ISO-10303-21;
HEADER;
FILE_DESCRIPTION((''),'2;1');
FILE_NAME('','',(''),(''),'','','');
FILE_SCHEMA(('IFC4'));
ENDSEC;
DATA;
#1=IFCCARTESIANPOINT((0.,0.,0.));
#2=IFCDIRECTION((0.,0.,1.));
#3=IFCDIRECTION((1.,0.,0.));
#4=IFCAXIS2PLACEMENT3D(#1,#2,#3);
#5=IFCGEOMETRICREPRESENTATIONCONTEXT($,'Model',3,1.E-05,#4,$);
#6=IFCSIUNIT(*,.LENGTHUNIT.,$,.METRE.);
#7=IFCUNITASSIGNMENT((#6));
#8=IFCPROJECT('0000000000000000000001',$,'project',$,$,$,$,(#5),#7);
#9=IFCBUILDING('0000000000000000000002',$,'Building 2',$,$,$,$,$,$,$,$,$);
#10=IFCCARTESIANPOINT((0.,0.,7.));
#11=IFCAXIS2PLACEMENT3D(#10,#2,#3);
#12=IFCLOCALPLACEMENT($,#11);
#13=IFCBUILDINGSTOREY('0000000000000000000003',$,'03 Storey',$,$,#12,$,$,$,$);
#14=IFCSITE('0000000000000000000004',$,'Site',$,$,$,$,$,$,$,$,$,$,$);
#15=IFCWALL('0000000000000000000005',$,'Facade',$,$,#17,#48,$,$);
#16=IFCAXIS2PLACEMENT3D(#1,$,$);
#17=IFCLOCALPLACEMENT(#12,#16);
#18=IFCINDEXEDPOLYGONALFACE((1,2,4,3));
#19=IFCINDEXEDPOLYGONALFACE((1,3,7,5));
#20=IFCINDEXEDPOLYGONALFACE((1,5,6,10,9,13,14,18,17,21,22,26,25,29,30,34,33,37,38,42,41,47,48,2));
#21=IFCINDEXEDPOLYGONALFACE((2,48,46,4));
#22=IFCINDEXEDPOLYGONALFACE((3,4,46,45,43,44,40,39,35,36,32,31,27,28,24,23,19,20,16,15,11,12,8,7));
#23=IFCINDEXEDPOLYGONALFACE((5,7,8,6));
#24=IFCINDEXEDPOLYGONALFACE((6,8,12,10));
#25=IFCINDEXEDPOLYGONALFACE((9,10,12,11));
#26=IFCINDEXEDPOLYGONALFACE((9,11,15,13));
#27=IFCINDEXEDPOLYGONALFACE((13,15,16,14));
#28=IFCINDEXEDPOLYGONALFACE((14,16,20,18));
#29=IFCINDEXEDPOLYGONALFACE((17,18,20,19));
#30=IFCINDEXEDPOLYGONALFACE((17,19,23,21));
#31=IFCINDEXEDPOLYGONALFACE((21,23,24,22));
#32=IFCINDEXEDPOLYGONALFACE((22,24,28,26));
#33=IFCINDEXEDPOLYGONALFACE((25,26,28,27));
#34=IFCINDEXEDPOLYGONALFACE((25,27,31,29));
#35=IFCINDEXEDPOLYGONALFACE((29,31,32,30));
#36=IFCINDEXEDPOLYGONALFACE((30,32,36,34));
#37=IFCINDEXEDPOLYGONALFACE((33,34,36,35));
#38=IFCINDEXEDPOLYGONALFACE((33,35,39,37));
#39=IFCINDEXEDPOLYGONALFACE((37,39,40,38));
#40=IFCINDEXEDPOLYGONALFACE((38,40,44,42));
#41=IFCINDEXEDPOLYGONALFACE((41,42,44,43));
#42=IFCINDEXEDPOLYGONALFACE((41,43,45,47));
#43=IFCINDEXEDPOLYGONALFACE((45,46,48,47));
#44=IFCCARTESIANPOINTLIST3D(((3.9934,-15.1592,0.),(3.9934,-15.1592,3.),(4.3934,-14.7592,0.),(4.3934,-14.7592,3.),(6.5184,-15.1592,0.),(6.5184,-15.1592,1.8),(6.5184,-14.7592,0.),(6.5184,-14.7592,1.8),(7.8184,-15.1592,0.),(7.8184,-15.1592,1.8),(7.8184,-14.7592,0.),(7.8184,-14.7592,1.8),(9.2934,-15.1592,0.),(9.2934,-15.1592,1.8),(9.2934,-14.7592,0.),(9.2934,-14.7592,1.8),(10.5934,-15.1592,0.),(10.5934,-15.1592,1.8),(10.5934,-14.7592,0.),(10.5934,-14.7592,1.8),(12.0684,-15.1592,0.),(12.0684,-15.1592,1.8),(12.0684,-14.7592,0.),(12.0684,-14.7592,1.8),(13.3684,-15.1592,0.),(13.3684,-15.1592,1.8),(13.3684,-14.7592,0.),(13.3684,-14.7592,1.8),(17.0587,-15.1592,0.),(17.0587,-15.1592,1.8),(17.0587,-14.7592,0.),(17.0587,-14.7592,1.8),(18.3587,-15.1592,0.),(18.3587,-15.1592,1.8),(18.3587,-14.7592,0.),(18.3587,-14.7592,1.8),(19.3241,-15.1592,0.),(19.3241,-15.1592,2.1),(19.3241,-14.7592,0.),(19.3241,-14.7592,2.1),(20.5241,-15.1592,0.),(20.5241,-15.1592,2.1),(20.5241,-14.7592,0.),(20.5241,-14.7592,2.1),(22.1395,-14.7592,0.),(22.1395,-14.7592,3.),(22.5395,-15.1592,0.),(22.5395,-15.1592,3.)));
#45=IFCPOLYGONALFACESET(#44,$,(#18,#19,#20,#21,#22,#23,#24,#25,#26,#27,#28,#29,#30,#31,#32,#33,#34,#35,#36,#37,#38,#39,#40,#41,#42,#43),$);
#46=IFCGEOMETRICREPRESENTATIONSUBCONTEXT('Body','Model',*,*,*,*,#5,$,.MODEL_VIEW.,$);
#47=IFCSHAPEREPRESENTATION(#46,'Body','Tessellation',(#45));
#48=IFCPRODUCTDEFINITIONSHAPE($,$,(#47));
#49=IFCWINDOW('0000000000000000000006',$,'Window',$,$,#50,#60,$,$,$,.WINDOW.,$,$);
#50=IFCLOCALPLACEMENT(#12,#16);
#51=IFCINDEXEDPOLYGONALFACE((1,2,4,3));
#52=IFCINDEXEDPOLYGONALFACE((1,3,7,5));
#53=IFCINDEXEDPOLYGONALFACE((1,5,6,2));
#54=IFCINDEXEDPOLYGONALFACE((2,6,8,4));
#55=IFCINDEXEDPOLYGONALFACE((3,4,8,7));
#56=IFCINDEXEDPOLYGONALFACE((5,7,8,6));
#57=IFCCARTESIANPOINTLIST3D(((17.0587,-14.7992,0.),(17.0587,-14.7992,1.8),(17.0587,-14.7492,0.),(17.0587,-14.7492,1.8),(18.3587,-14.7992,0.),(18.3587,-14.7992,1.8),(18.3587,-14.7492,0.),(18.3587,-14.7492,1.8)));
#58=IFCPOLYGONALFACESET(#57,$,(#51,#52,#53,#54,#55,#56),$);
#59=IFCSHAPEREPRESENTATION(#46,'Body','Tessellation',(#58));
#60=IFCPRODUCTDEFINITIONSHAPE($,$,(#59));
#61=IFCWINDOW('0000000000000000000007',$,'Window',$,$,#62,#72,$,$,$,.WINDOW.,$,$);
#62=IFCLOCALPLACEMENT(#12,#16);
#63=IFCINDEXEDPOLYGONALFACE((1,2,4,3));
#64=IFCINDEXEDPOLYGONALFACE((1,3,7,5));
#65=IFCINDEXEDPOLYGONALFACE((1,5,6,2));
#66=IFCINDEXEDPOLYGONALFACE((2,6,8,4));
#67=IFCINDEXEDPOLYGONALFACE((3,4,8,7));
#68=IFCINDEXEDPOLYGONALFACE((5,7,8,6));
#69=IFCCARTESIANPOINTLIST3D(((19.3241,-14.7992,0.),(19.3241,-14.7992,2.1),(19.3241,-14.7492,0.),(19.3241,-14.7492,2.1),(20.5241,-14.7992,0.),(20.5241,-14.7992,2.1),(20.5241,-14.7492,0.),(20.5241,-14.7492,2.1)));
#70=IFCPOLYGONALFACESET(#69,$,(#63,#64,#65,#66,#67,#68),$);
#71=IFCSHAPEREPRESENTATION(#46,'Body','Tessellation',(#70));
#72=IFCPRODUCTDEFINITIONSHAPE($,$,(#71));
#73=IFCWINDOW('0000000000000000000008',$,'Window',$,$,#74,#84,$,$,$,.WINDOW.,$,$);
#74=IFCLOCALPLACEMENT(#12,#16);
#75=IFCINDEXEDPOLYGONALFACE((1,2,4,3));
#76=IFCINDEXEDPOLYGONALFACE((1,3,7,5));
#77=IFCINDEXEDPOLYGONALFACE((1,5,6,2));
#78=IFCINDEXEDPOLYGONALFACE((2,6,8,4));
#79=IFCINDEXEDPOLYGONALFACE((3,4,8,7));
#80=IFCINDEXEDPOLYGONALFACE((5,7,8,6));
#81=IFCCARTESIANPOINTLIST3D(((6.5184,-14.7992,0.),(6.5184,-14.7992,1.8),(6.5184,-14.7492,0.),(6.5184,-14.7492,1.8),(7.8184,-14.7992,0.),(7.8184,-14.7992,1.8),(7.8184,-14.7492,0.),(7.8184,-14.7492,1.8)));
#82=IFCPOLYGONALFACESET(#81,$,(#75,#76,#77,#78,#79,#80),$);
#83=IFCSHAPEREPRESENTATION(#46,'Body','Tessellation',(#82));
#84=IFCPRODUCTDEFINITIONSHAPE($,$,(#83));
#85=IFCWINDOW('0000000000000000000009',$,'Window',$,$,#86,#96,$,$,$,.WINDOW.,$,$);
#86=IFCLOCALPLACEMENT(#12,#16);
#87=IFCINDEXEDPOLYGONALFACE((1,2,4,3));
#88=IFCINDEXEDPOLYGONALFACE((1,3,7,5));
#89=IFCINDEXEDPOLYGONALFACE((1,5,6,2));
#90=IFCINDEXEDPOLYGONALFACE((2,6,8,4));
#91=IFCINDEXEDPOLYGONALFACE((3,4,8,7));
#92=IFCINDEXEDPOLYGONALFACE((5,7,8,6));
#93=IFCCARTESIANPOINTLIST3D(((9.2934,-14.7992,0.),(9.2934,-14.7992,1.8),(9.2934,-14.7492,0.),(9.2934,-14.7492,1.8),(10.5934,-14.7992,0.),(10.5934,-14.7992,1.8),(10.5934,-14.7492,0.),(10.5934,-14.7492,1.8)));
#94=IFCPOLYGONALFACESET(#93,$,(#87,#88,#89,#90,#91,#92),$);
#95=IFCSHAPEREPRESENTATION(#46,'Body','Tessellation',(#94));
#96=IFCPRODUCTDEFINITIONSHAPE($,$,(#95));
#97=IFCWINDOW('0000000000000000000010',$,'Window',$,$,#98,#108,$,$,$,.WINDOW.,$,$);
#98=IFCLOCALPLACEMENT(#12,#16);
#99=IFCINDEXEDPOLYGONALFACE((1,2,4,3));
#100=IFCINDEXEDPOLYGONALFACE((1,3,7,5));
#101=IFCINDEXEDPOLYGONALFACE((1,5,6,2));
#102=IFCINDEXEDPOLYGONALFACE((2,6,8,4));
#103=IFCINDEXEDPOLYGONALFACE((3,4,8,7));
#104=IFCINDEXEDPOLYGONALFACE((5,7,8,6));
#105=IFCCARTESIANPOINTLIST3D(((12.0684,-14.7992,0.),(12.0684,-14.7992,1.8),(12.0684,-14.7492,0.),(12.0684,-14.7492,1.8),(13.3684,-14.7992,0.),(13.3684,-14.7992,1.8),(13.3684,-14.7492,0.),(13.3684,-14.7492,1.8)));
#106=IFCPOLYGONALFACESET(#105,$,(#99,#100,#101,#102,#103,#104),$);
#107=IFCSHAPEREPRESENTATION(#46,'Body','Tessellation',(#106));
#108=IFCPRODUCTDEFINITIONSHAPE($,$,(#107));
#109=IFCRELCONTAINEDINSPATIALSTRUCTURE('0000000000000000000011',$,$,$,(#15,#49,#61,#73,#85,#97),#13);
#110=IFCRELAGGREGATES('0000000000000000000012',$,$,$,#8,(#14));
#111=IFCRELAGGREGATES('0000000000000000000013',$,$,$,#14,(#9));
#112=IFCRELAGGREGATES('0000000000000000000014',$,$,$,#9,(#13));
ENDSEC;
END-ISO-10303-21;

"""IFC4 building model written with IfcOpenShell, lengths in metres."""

from ifc_helpers import new_model, si_unit, frame, origin_with_axes, place, context, subcontext, project, spatial, line, indexed_curve, outline, extrude, element, fill, save


model = new_model("IFC4")

# Units and contexts
model_context = context("Model", 3, precision=1e-05, world=origin_with_axes())
body_context = subcontext(model_context, "Body", "Model", "MODEL_VIEW")
ifc_project = project(units=[si_unit("LENGTHUNIT", "METRE")], contexts=[model_context])

# Site, building, storey
site = spatial("IfcSite", under=ifc_project, Name="Site")
building = spatial("IfcBuilding", under=site, Name="Building 2")
storey_placement = place(None, frame((0.0, 0.0, 7.0), z_axis=(0.0, 0.0, 1.0), x_axis=(1.0, 0.0, 0.0)))
storey = spatial("IfcBuildingStorey", under=building, at=storey_placement, Name="03 Storey")

# Wall, openings, windows
wall_1_placement = place(storey_placement, origin_with_axes())
wall_1 = element("IfcWall", 1, at=wall_1_placement, inside=storey, Name="Facade", context=body_context, shape_type="SweptSolid", body=[
    extrude(outline(indexed_curve([(4.3934, -14.7592), (22.1395, -14.7592), (22.5395, -15.1592), (3.9934, -15.1592)], segments=[line(1, 2), line(2, 3), line(3, 4)])), origin_with_axes(), (0.0, 0.0, 1.0), 3.0),
])
opening_1_placement = place(wall_1_placement, origin_with_axes())
opening_1 = element("IfcOpeningElement", 2, at=opening_1_placement, cuts=wall_1, context=body_context, shape_type="SweptSolid", body=[
    extrude(outline(indexed_curve([(17.0587, -15.1992), (17.0587, -14.6992), (18.3587, -14.6992), (18.3587, -15.1992)], segments=[line(1, 2), line(2, 3), line(3, 4)])), origin_with_axes(), (0.0, 0.0, 1.0), 1.8),
])
opening_2_placement = place(wall_1_placement, origin_with_axes())
opening_2 = element("IfcOpeningElement", 3, at=opening_2_placement, cuts=wall_1, context=body_context, shape_type="SweptSolid", body=[
    extrude(outline(indexed_curve([(19.3241, -15.1992), (19.3241, -14.6992), (20.5241, -14.6992), (20.5241, -15.1992)], segments=[line(1, 2), line(2, 3), line(3, 4)])), origin_with_axes(), (0.0, 0.0, 1.0), 2.1),
])
opening_3_placement = place(wall_1_placement, origin_with_axes())
opening_3 = element("IfcOpeningElement", 4, at=opening_3_placement, cuts=wall_1, context=body_context, shape_type="SweptSolid", body=[
    extrude(outline(indexed_curve([(6.5184, -15.1992), (6.5184, -14.6992), (7.8184, -14.6992), (7.8184, -15.1992)], segments=[line(1, 2), line(2, 3), line(3, 4)])), origin_with_axes(), (0.0, 0.0, 1.0), 1.8),
])
opening_4_placement = place(wall_1_placement, origin_with_axes())
opening_4 = element("IfcOpeningElement", 5, at=opening_4_placement, cuts=wall_1, context=body_context, shape_type="SweptSolid", body=[
    extrude(outline(indexed_curve([(9.2934, -15.1992), (9.2934, -14.6992), (10.5934, -14.6992), (10.5934, -15.1992)], segments=[line(1, 2), line(2, 3), line(3, 4)])), origin_with_axes(), (0.0, 0.0, 1.0), 1.8),
])
opening_5_placement = place(wall_1_placement, origin_with_axes())
opening_5 = element("IfcOpeningElement", 6, at=opening_5_placement, cuts=wall_1, context=body_context, shape_type="SweptSolid", body=[
    extrude(outline(indexed_curve([(12.0684, -15.1992), (12.0684, -14.6992), (13.3684, -14.6992), (13.3684, -15.1992)], segments=[line(1, 2), line(2, 3), line(3, 4)])), origin_with_axes(), (0.0, 0.0, 1.0), 1.8),
])
window_1_placement = place(storey_placement, origin_with_axes())
window_1 = element("IfcWindow", 7, at=window_1_placement, inside=storey, Name="Window", PredefinedType="WINDOW", context=body_context, shape_type="SweptSolid", body=[
    extrude(outline(indexed_curve([(17.0587, -14.7992), (17.0587, -14.7492), (18.3587, -14.7492), (18.3587, -14.7992)], segments=[line(1, 2), line(2, 3), line(3, 4)])), origin_with_axes(), (0.0, 0.0, 1.0), 1.8),
])
fill(opening_1, window_1)
window_2_placement = place(storey_placement, origin_with_axes())
window_2 = element("IfcWindow", 8, at=window_2_placement, inside=storey, Name="Window", PredefinedType="WINDOW", context=body_context, shape_type="SweptSolid", body=[
    extrude(outline(indexed_curve([(19.3241, -14.7992), (19.3241, -14.7492), (20.5241, -14.7492), (20.5241, -14.7992)], segments=[line(1, 2), line(2, 3), line(3, 4)])), origin_with_axes(), (0.0, 0.0, 1.0), 2.1),
])
fill(opening_2, window_2)
window_3_placement = place(storey_placement, origin_with_axes())
window_3 = element("IfcWindow", 9, at=window_3_placement, inside=storey, Name="Window", PredefinedType="WINDOW", context=body_context, shape_type="SweptSolid", body=[
    extrude(outline(indexed_curve([(6.5184, -14.7992), (6.5184, -14.7492), (7.8184, -14.7492), (7.8184, -14.7992)], segments=[line(1, 2), line(2, 3), line(3, 4)])), origin_with_axes(), (0.0, 0.0, 1.0), 1.8),
])
fill(opening_3, window_3)
window_4_placement = place(storey_placement, origin_with_axes())
window_4 = element("IfcWindow", 10, at=window_4_placement, inside=storey, Name="Window", PredefinedType="WINDOW", context=body_context, shape_type="SweptSolid", body=[
    extrude(outline(indexed_curve([(9.2934, -14.7992), (9.2934, -14.7492), (10.5934, -14.7492), (10.5934, -14.7992)], segments=[line(1, 2), line(2, 3), line(3, 4)])), origin_with_axes(), (0.0, 0.0, 1.0), 1.8),
])
fill(opening_4, window_4)
window_5_placement = place(storey_placement, origin_with_axes())
window_5 = element("IfcWindow", 11, at=window_5_placement, inside=storey, Name="Window", PredefinedType="WINDOW", context=body_context, shape_type="SweptSolid", body=[
    extrude(outline(indexed_curve([(12.0684, -14.7992), (12.0684, -14.7492), (13.3684, -14.7492), (13.3684, -14.7992)], segments=[line(1, 2), line(2, 3), line(3, 4)])), origin_with_axes(), (0.0, 0.0, 1.0), 1.8),
])
fill(opening_5, window_5)

save(model, "model.ifc")
